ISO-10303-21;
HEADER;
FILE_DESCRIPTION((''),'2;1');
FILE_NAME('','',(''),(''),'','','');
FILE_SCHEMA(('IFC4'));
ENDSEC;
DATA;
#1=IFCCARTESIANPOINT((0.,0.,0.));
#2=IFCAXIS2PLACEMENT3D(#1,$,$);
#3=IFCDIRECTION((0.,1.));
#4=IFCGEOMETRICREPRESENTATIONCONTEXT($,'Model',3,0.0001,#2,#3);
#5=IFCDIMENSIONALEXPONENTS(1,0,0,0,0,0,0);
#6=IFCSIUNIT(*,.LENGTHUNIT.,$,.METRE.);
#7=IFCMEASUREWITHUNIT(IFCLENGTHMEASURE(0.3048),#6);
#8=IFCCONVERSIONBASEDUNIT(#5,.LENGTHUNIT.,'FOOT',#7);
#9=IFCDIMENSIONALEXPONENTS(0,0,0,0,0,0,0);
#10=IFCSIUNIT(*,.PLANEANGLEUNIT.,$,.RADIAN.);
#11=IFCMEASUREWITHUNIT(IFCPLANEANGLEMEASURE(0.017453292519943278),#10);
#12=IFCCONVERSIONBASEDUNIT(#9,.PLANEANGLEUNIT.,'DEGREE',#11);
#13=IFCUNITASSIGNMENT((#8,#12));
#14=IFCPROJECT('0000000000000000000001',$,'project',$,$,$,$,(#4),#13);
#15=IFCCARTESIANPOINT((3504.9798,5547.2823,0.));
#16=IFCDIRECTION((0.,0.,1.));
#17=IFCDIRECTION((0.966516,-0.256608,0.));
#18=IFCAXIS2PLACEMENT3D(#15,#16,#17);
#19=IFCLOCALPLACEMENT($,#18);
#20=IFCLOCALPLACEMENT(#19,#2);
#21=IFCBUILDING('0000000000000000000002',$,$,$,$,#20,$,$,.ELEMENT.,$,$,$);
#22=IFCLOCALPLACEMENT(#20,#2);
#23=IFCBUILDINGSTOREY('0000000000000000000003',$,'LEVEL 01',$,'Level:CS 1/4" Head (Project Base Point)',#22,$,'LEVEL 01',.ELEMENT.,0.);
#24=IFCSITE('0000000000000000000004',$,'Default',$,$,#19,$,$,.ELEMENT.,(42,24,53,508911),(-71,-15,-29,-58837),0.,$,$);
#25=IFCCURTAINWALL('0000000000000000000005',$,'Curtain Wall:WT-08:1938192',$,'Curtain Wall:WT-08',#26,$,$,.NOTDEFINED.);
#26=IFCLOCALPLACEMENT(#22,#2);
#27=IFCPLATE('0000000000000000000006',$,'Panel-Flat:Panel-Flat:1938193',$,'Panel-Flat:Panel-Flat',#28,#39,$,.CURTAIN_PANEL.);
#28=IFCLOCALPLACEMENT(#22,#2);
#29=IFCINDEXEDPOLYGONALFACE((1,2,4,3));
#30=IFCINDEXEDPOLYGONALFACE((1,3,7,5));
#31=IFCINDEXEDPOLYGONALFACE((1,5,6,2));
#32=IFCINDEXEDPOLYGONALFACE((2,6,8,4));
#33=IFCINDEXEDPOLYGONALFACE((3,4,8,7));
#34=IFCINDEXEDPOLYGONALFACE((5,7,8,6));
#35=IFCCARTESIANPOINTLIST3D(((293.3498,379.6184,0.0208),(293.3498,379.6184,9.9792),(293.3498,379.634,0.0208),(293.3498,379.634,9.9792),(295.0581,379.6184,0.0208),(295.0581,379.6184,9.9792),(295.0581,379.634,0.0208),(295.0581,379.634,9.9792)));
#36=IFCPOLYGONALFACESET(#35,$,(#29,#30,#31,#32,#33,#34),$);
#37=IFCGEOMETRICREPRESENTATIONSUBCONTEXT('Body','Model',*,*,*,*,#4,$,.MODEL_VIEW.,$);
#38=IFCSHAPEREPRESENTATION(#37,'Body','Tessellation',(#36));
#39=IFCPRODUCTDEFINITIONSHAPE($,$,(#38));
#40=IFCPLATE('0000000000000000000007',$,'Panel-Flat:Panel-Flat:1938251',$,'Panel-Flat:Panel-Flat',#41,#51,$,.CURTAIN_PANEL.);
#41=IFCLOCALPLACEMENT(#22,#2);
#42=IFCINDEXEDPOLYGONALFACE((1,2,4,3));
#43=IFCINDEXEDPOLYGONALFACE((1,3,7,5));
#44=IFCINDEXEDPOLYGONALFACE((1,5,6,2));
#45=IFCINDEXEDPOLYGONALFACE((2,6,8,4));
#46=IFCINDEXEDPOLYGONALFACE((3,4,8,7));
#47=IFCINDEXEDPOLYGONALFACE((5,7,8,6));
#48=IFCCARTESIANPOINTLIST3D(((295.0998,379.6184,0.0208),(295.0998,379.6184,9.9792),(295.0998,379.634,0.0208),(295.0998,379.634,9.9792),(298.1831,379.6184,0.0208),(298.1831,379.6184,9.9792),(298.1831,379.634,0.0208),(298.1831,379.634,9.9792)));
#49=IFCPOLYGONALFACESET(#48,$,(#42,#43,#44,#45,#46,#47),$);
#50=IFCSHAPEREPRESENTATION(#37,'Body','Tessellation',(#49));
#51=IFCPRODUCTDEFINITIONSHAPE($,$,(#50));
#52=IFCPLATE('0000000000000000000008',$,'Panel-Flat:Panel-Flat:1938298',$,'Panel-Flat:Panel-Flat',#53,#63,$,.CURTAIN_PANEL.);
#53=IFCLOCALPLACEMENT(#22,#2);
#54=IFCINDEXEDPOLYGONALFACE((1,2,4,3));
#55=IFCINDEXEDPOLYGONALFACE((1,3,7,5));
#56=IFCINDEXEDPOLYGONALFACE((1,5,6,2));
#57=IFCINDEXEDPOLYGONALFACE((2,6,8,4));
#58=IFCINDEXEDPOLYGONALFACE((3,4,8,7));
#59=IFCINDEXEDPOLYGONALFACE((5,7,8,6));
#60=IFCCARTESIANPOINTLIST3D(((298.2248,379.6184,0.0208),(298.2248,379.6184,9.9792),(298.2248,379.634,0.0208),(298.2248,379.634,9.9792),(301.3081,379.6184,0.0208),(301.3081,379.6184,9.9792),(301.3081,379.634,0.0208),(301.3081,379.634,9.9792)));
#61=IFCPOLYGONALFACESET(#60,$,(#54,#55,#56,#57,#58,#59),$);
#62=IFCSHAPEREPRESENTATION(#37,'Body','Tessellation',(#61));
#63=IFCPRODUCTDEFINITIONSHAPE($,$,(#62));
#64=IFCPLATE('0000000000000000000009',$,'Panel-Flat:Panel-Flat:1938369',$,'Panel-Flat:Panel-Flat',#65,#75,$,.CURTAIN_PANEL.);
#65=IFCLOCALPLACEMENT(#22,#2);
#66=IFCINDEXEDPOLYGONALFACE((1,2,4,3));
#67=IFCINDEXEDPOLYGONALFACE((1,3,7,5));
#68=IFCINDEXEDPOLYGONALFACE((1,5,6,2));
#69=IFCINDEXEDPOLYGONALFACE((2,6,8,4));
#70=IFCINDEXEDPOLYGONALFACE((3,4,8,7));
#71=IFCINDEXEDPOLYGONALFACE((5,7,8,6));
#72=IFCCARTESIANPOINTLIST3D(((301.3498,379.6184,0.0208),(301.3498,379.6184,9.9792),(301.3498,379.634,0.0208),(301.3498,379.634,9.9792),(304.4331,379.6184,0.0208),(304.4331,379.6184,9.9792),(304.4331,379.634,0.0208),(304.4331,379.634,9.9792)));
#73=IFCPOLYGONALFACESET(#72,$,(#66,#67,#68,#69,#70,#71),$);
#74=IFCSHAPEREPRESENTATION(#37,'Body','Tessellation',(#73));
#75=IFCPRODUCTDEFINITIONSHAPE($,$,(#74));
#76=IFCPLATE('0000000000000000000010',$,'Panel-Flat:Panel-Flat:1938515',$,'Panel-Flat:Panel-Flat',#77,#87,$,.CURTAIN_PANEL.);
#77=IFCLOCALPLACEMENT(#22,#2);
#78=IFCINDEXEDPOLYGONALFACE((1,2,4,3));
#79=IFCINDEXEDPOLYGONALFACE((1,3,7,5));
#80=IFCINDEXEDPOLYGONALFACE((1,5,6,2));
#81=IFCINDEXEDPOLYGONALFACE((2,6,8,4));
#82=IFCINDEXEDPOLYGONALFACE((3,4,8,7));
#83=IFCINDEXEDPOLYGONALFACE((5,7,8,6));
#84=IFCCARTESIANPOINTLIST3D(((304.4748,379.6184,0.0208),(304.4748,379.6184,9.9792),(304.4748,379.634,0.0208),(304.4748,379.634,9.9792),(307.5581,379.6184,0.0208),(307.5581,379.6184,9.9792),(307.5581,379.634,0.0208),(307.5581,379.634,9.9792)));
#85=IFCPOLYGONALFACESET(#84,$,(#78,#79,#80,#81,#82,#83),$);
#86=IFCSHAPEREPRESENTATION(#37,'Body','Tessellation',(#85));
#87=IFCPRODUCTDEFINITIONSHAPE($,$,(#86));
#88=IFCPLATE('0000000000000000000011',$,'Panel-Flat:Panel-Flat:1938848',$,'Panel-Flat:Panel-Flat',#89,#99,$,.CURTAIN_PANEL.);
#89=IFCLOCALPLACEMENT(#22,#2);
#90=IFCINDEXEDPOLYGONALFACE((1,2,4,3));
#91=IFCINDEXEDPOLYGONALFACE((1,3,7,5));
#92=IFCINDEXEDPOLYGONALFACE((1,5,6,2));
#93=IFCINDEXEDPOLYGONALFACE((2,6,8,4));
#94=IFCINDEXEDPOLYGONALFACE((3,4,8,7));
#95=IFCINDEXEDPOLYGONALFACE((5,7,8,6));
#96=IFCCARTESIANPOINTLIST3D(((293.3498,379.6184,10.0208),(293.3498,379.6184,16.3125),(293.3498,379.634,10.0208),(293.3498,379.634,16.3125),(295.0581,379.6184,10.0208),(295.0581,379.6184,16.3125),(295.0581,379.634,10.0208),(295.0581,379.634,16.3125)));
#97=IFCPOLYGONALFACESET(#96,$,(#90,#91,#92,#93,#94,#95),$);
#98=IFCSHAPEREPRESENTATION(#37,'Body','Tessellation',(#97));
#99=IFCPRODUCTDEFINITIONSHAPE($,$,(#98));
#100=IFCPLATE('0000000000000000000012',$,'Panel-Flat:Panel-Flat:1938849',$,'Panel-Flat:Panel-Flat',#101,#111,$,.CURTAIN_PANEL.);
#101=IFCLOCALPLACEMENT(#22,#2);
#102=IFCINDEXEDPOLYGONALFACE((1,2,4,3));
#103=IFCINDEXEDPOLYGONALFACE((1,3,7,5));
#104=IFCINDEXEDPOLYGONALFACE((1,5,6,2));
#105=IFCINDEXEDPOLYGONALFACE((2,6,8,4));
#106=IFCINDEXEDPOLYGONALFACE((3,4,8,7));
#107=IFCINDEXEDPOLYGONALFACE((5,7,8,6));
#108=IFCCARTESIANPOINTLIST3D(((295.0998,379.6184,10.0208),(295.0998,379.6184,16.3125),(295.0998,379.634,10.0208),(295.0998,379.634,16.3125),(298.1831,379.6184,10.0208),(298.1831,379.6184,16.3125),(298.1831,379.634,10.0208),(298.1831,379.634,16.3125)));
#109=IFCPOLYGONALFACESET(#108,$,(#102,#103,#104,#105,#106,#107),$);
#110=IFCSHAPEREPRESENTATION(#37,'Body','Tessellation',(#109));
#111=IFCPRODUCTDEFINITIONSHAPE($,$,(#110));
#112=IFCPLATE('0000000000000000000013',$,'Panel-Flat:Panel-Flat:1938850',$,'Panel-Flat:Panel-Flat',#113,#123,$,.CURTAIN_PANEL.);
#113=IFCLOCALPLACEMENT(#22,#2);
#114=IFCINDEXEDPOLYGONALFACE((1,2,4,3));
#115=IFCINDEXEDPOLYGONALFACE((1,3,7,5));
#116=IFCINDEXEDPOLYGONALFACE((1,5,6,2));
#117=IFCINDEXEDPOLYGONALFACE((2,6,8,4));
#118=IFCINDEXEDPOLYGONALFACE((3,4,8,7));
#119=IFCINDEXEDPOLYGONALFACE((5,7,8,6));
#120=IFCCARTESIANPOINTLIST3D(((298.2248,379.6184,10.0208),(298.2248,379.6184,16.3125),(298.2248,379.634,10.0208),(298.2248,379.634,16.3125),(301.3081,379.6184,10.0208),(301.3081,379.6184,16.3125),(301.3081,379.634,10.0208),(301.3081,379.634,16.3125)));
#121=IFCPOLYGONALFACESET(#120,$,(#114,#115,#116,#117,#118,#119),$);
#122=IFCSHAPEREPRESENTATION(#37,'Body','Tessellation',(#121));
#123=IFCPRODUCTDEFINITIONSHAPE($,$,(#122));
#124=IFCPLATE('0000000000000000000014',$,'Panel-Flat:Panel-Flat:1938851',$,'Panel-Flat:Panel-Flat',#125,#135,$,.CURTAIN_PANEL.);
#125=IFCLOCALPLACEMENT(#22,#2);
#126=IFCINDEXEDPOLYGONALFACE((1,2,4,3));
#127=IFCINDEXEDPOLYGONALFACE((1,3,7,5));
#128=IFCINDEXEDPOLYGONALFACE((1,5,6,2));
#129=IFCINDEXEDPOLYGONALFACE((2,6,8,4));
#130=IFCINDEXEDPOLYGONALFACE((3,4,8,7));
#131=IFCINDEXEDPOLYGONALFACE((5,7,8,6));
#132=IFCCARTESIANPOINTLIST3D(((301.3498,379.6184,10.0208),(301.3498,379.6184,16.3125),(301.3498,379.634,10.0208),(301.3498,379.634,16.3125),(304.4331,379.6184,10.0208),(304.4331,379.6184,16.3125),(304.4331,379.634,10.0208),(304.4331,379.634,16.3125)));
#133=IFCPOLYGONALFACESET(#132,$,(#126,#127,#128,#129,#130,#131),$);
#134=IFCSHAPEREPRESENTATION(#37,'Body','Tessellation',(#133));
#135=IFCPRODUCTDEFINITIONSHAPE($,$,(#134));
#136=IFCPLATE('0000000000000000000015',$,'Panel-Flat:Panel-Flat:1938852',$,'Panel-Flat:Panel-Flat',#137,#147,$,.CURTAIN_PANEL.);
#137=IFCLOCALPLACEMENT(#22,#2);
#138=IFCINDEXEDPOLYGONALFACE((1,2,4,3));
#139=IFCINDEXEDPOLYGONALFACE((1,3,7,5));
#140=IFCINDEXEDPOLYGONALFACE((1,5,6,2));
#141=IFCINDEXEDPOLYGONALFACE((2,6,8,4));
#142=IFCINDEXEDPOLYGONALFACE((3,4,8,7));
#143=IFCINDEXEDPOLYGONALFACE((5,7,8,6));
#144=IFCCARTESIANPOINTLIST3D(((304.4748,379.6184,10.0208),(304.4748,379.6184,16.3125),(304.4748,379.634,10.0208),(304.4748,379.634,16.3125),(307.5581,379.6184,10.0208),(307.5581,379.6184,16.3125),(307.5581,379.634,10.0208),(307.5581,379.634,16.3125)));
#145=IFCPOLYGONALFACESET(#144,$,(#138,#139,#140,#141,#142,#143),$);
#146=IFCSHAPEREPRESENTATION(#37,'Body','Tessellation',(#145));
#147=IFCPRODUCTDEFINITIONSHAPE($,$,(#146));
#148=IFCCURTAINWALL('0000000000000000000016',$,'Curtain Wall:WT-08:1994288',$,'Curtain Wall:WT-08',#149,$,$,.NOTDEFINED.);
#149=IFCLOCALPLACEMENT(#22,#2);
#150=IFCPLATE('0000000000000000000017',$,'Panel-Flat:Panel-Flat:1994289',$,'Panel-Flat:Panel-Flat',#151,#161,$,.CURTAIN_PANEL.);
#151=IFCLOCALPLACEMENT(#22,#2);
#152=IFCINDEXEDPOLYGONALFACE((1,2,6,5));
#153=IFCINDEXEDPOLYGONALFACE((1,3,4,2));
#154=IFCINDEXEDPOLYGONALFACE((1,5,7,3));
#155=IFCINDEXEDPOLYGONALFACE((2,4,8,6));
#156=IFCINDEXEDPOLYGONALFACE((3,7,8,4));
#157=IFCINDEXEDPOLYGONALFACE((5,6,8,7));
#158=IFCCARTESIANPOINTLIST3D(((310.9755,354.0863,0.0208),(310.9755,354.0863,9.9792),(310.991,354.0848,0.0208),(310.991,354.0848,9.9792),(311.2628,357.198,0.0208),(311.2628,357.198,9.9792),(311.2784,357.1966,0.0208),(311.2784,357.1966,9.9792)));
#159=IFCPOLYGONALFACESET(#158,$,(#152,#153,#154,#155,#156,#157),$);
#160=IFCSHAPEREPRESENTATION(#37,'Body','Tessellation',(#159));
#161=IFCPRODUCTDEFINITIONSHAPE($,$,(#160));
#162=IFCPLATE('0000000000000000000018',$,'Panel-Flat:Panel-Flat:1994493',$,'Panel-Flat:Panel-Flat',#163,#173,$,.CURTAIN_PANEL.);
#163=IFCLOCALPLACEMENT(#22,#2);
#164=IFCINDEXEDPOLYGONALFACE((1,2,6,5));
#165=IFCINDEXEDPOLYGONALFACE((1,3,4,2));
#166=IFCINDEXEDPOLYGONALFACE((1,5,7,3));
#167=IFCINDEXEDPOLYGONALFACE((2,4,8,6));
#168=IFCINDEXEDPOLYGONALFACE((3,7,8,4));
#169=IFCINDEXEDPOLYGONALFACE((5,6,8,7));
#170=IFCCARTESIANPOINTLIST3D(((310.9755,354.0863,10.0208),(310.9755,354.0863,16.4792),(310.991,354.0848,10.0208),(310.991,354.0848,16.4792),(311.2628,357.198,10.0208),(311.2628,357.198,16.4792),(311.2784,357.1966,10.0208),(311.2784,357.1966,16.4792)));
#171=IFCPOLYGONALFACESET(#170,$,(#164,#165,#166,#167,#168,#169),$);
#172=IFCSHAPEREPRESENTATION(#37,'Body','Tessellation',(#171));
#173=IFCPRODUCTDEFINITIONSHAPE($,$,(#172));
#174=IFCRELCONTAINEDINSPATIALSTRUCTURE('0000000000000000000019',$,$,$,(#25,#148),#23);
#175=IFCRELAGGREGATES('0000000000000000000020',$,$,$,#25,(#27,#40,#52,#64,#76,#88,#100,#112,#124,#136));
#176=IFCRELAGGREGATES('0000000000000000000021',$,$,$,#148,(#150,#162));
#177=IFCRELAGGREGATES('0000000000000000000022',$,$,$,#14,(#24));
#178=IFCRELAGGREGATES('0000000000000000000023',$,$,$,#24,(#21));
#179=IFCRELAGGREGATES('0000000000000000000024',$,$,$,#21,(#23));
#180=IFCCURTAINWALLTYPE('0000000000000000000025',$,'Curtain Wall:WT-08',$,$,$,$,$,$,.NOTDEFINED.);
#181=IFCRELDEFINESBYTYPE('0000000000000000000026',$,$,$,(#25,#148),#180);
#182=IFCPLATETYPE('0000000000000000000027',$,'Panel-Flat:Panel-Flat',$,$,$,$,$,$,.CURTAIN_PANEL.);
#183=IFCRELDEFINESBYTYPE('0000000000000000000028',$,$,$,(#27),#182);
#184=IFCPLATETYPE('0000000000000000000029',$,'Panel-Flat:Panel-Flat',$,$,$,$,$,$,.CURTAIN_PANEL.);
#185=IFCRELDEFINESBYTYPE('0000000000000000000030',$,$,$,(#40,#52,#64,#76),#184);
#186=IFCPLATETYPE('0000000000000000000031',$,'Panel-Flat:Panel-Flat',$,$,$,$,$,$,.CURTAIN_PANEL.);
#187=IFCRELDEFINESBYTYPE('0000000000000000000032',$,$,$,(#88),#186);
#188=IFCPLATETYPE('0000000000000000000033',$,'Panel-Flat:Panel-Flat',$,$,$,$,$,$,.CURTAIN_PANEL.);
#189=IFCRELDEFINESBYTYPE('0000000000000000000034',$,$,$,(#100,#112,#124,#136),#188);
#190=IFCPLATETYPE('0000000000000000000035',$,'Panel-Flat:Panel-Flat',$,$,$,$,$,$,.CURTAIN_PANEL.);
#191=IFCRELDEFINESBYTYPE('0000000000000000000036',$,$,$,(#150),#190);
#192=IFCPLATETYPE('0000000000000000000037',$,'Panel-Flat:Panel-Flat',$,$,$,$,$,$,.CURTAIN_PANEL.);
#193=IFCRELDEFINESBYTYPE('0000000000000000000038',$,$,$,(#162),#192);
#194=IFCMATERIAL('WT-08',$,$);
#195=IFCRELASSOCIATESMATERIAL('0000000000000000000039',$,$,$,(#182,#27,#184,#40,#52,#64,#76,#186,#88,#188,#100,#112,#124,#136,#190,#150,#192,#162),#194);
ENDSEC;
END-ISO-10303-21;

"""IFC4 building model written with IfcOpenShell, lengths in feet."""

from ifc_helpers import new_model, entity, si_unit, converted_unit, direction, frame, origin, place, context, subcontext, project, spatial, indexed_curve, outline, extrude, source, transform, mapped, material, type_object, type_shapes, element, aggregate, save


model = new_model("IFC4")

# Units and contexts
model_context = context("Model", 3, precision=0.0001, world=origin(), true_north=direction((0.0, 1.0)))
body_context = subcontext(model_context, "Body", "Model", "MODEL_VIEW")
ifc_project = project(units=[converted_unit("LENGTHUNIT", "FOOT", entity("IfcLengthMeasure", 0.3048), si_unit("LENGTHUNIT", "METRE"), dimensions=[1, 0, 0, 0, 0, 0, 0]), converted_unit("PLANEANGLEUNIT", "DEGREE", entity("IfcPlaneAngleMeasure", 0.017453292519943278), si_unit("PLANEANGLEUNIT", "RADIAN"), dimensions=[0, 0, 0, 0, 0, 0, 0])], contexts=[model_context])

# Site, building, storey
site_placement = place(None, frame((3504.9798, 5547.2823, 0.0), z_axis=(0.0, 0.0, 1.0), x_axis=(0.966516, -0.256608, 0.0)))
site = spatial("IfcSite", under=ifc_project, at=site_placement, Name="Default", CompositionType="ELEMENT", RefLatitude=(42, 24, 53, 508911), RefLongitude=(-71, -15, -29, -58837), RefElevation=0.0)
building_placement = place(site_placement, origin())
building = spatial("IfcBuilding", under=site, at=building_placement, CompositionType="ELEMENT")
storey_placement = place(building_placement, origin())
storey = spatial("IfcBuildingStorey", under=building, at=storey_placement, Name="LEVEL 01", ObjectType="Level:CS 1/4\" Head (Project Base Point)", LongName="LEVEL 01", CompositionType="ELEMENT", Elevation=0.0)

# Curtain wall, plates
curtain_wall_type_1 = type_object("IfcCurtainWallType", Name="Curtain Wall:WT-08", PredefinedType="NOTDEFINED")
curtain_wall_1_placement = place(storey_placement, origin())
curtain_wall_1 = element("IfcCurtainWall", 1, at=curtain_wall_1_placement, inside=storey, type_object=curtain_wall_type_1, Name="Curtain Wall:WT-08:1938192", ObjectType="Curtain Wall:WT-08", PredefinedType="NOTDEFINED")
ifc_material_1 = material(Name="WT-08")
plate_type_1 = type_object("IfcPlateType", Name="Panel-Flat:Panel-Flat", PredefinedType="CURTAIN_PANEL", material=ifc_material_1)
shared_shape_1 = source(origin(), body_context, "Body", "SweptSolid", [
    extrude(outline(indexed_curve([(-0.0078, -0.8542), (0.0078, -0.8542), (0.0078, 0.8542), (-0.0078, 0.8542), (-0.0078, -0.8542)], self_intersect=False)), frame((0.0, -0.0078, 0.0208), z_axis=(0.0, 0.0, 1.0), x_axis=(0.0, -1.0, 0.0)), (0.0, 0.0, 1.0), 9.9583),
])
type_shapes(plate_type_1, [shared_shape_1])
plate_1_placement = place(curtain_wall_1_placement, frame((294.2039, 379.634, 0.0)))
plate_1 = element("IfcPlate", 2, at=plate_1_placement, type_object=plate_type_1, material=ifc_material_1, Name="Panel-Flat:Panel-Flat:1938193", ObjectType="Panel-Flat:Panel-Flat", PredefinedType="CURTAIN_PANEL", context=body_context, shape_type="MappedRepresentation", body=[
    mapped(shared_shape_1, transform((0.0, 0.0, 0.0), scale=1.0)),
])
plate_type_2 = type_object("IfcPlateType", Name="Panel-Flat:Panel-Flat", PredefinedType="CURTAIN_PANEL", material=ifc_material_1)
shared_shape_2 = source(origin(), body_context, "Body", "SweptSolid", [
    extrude(outline(indexed_curve([(-0.0078, -1.5417), (0.0078, -1.5417), (0.0078, 1.5417), (-0.0078, 1.5417), (-0.0078, -1.5417)], self_intersect=False)), frame((0.0, -0.0078, 0.0208), z_axis=(0.0, 0.0, 1.0), x_axis=(0.0, -1.0, 0.0)), (0.0, 0.0, 1.0), 9.9583),
])
type_shapes(plate_type_2, [shared_shape_2])
plate_2_placement = place(curtain_wall_1_placement, frame((296.6414, 379.634, 0.0)))
plate_2 = element("IfcPlate", 3, at=plate_2_placement, type_object=plate_type_2, material=ifc_material_1, Name="Panel-Flat:Panel-Flat:1938251", ObjectType="Panel-Flat:Panel-Flat", PredefinedType="CURTAIN_PANEL", context=body_context, shape_type="MappedRepresentation", body=[
    mapped(shared_shape_2, transform((0.0, 0.0, 0.0), scale=1.0)),
])
plate_3_placement = place(curtain_wall_1_placement, frame((299.7664, 379.634, 0.0)))
plate_3 = element("IfcPlate", 4, at=plate_3_placement, type_object=plate_type_2, material=ifc_material_1, Name="Panel-Flat:Panel-Flat:1938298", ObjectType="Panel-Flat:Panel-Flat", PredefinedType="CURTAIN_PANEL", context=body_context, shape_type="MappedRepresentation", body=[
    mapped(shared_shape_2, transform((0.0, 0.0, 0.0), scale=1.0)),
])
plate_4_placement = place(curtain_wall_1_placement, frame((302.8914, 379.634, 0.0)))
plate_4 = element("IfcPlate", 5, at=plate_4_placement, type_object=plate_type_2, material=ifc_material_1, Name="Panel-Flat:Panel-Flat:1938369", ObjectType="Panel-Flat:Panel-Flat", PredefinedType="CURTAIN_PANEL", context=body_context, shape_type="MappedRepresentation", body=[
    mapped(shared_shape_2, transform((0.0, 0.0, 0.0), scale=1.0)),
])
plate_5_placement = place(curtain_wall_1_placement, frame((306.0164, 379.634, 0.0)))
plate_5 = element("IfcPlate", 6, at=plate_5_placement, type_object=plate_type_2, material=ifc_material_1, Name="Panel-Flat:Panel-Flat:1938515", ObjectType="Panel-Flat:Panel-Flat", PredefinedType="CURTAIN_PANEL", context=body_context, shape_type="MappedRepresentation", body=[
    mapped(shared_shape_2, transform((0.0, 0.0, 0.0), scale=1.0)),
])
plate_type_3 = type_object("IfcPlateType", Name="Panel-Flat:Panel-Flat", PredefinedType="CURTAIN_PANEL", material=ifc_material_1)
shared_shape_3 = source(origin(), body_context, "Body", "SweptSolid", [
    extrude(outline(indexed_curve([(-0.0078, -0.8542), (0.0078, -0.8542), (0.0078, 0.8542), (-0.0078, 0.8542), (-0.0078, -0.8542)], self_intersect=False)), frame((0.0, -0.0078, 0.0208), z_axis=(0.0, 0.0, 1.0), x_axis=(0.0, -1.0, 0.0)), (0.0, 0.0, 1.0), 6.2917),
])
type_shapes(plate_type_3, [shared_shape_3])
plate_6_placement = place(curtain_wall_1_placement, frame((294.2039, 379.634, 10.0)))
plate_6 = element("IfcPlate", 7, at=plate_6_placement, type_object=plate_type_3, material=ifc_material_1, Name="Panel-Flat:Panel-Flat:1938848", ObjectType="Panel-Flat:Panel-Flat", PredefinedType="CURTAIN_PANEL", context=body_context, shape_type="MappedRepresentation", body=[
    mapped(shared_shape_3, transform((0.0, 0.0, 0.0), scale=1.0)),
])
plate_type_4 = type_object("IfcPlateType", Name="Panel-Flat:Panel-Flat", PredefinedType="CURTAIN_PANEL", material=ifc_material_1)
shared_shape_4 = source(origin(), body_context, "Body", "SweptSolid", [
    extrude(outline(indexed_curve([(-0.0078, -1.5417), (0.0078, -1.5417), (0.0078, 1.5417), (-0.0078, 1.5417), (-0.0078, -1.5417)], self_intersect=False)), frame((0.0, -0.0078, 0.0208), z_axis=(0.0, 0.0, 1.0), x_axis=(0.0, -1.0, 0.0)), (0.0, 0.0, 1.0), 6.2917),
])
type_shapes(plate_type_4, [shared_shape_4])
plate_7_placement = place(curtain_wall_1_placement, frame((296.6414, 379.634, 10.0)))
plate_7 = element("IfcPlate", 8, at=plate_7_placement, type_object=plate_type_4, material=ifc_material_1, Name="Panel-Flat:Panel-Flat:1938849", ObjectType="Panel-Flat:Panel-Flat", PredefinedType="CURTAIN_PANEL", context=body_context, shape_type="MappedRepresentation", body=[
    mapped(shared_shape_4, transform((0.0, 0.0, 0.0), scale=1.0)),
])
plate_8_placement = place(curtain_wall_1_placement, frame((299.7664, 379.634, 10.0)))
plate_8 = element("IfcPlate", 9, at=plate_8_placement, type_object=plate_type_4, material=ifc_material_1, Name="Panel-Flat:Panel-Flat:1938850", ObjectType="Panel-Flat:Panel-Flat", PredefinedType="CURTAIN_PANEL", context=body_context, shape_type="MappedRepresentation", body=[
    mapped(shared_shape_4, transform((0.0, 0.0, 0.0), scale=1.0)),
])
plate_9_placement = place(curtain_wall_1_placement, frame((302.8914, 379.634, 10.0)))
plate_9 = element("IfcPlate", 10, at=plate_9_placement, type_object=plate_type_4, material=ifc_material_1, Name="Panel-Flat:Panel-Flat:1938851", ObjectType="Panel-Flat:Panel-Flat", PredefinedType="CURTAIN_PANEL", context=body_context, shape_type="MappedRepresentation", body=[
    mapped(shared_shape_4, transform((0.0, 0.0, 0.0), scale=1.0)),
])
plate_10_placement = place(curtain_wall_1_placement, frame((306.0164, 379.634, 10.0)))
plate_10 = element("IfcPlate", 11, at=plate_10_placement, type_object=plate_type_4, material=ifc_material_1, Name="Panel-Flat:Panel-Flat:1938852", ObjectType="Panel-Flat:Panel-Flat", PredefinedType="CURTAIN_PANEL", context=body_context, shape_type="MappedRepresentation", body=[
    mapped(shared_shape_4, transform((0.0, 0.0, 0.0), scale=1.0)),
])
aggregate(curtain_wall_1, [plate_1, plate_2, plate_3, plate_4, plate_5, plate_6, plate_7, plate_8, plate_9, plate_10])

# Curtain wall, plates
curtain_wall_2_placement = place(storey_placement, origin())
curtain_wall_2 = element("IfcCurtainWall", 12, at=curtain_wall_2_placement, inside=storey, type_object=curtain_wall_type_1, Name="Curtain Wall:WT-08:1994288", ObjectType="Curtain Wall:WT-08", PredefinedType="NOTDEFINED")
plate_type_5 = type_object("IfcPlateType", Name="Panel-Flat:Panel-Flat", PredefinedType="CURTAIN_PANEL", material=ifc_material_1)
shared_shape_5 = source(origin(), body_context, "Body", "SweptSolid", [
    extrude(outline(indexed_curve([(-0.0078, -1.5625), (0.0078, -1.5625), (0.0078, 1.5625), (-0.0078, 1.5625), (-0.0078, -1.5625)], self_intersect=False)), frame((0.0, -0.0078, 0.0208), z_axis=(0.0, 0.0, 1.0), x_axis=(0.0, -1.0, 0.0)), (0.0, 0.0, 1.0), 9.9583),
])
type_shapes(plate_type_5, [shared_shape_5])
plate_11_placement = place(curtain_wall_2_placement, frame((311.1347, 355.6407, 0.0), z_axis=(0.0, 0.0, 1.0), x_axis=(-0.091962, -0.995763, 0.0)))
plate_11 = element("IfcPlate", 13, at=plate_11_placement, type_object=plate_type_5, material=ifc_material_1, Name="Panel-Flat:Panel-Flat:1994289", ObjectType="Panel-Flat:Panel-Flat", PredefinedType="CURTAIN_PANEL", context=body_context, shape_type="MappedRepresentation", body=[
    mapped(shared_shape_5, transform((0.0, 0.0, 0.0), scale=1.0)),
])
plate_type_6 = type_object("IfcPlateType", Name="Panel-Flat:Panel-Flat", PredefinedType="CURTAIN_PANEL", material=ifc_material_1)
shared_shape_6 = source(origin(), body_context, "Body", "SweptSolid", [
    extrude(outline(indexed_curve([(-0.0078, -1.5625), (0.0078, -1.5625), (0.0078, 1.5625), (-0.0078, 1.5625), (-0.0078, -1.5625)], self_intersect=False)), frame((0.0, -0.0078, 0.0208), z_axis=(0.0, 0.0, 1.0), x_axis=(0.0, -1.0, 0.0)), (0.0, 0.0, 1.0), 6.4583),
])
type_shapes(plate_type_6, [shared_shape_6])
plate_12_placement = place(curtain_wall_2_placement, frame((311.1347, 355.6407, 10.0), z_axis=(0.0, 0.0, 1.0), x_axis=(-0.091962, -0.995763, 0.0)))
plate_12 = element("IfcPlate", 14, at=plate_12_placement, type_object=plate_type_6, material=ifc_material_1, Name="Panel-Flat:Panel-Flat:1994493", ObjectType="Panel-Flat:Panel-Flat", PredefinedType="CURTAIN_PANEL", context=body_context, shape_type="MappedRepresentation", body=[
    mapped(shared_shape_6, transform((0.0, 0.0, 0.0), scale=1.0)),
])
aggregate(curtain_wall_2, [plate_11, plate_12])

save(model, "model.ifc")
